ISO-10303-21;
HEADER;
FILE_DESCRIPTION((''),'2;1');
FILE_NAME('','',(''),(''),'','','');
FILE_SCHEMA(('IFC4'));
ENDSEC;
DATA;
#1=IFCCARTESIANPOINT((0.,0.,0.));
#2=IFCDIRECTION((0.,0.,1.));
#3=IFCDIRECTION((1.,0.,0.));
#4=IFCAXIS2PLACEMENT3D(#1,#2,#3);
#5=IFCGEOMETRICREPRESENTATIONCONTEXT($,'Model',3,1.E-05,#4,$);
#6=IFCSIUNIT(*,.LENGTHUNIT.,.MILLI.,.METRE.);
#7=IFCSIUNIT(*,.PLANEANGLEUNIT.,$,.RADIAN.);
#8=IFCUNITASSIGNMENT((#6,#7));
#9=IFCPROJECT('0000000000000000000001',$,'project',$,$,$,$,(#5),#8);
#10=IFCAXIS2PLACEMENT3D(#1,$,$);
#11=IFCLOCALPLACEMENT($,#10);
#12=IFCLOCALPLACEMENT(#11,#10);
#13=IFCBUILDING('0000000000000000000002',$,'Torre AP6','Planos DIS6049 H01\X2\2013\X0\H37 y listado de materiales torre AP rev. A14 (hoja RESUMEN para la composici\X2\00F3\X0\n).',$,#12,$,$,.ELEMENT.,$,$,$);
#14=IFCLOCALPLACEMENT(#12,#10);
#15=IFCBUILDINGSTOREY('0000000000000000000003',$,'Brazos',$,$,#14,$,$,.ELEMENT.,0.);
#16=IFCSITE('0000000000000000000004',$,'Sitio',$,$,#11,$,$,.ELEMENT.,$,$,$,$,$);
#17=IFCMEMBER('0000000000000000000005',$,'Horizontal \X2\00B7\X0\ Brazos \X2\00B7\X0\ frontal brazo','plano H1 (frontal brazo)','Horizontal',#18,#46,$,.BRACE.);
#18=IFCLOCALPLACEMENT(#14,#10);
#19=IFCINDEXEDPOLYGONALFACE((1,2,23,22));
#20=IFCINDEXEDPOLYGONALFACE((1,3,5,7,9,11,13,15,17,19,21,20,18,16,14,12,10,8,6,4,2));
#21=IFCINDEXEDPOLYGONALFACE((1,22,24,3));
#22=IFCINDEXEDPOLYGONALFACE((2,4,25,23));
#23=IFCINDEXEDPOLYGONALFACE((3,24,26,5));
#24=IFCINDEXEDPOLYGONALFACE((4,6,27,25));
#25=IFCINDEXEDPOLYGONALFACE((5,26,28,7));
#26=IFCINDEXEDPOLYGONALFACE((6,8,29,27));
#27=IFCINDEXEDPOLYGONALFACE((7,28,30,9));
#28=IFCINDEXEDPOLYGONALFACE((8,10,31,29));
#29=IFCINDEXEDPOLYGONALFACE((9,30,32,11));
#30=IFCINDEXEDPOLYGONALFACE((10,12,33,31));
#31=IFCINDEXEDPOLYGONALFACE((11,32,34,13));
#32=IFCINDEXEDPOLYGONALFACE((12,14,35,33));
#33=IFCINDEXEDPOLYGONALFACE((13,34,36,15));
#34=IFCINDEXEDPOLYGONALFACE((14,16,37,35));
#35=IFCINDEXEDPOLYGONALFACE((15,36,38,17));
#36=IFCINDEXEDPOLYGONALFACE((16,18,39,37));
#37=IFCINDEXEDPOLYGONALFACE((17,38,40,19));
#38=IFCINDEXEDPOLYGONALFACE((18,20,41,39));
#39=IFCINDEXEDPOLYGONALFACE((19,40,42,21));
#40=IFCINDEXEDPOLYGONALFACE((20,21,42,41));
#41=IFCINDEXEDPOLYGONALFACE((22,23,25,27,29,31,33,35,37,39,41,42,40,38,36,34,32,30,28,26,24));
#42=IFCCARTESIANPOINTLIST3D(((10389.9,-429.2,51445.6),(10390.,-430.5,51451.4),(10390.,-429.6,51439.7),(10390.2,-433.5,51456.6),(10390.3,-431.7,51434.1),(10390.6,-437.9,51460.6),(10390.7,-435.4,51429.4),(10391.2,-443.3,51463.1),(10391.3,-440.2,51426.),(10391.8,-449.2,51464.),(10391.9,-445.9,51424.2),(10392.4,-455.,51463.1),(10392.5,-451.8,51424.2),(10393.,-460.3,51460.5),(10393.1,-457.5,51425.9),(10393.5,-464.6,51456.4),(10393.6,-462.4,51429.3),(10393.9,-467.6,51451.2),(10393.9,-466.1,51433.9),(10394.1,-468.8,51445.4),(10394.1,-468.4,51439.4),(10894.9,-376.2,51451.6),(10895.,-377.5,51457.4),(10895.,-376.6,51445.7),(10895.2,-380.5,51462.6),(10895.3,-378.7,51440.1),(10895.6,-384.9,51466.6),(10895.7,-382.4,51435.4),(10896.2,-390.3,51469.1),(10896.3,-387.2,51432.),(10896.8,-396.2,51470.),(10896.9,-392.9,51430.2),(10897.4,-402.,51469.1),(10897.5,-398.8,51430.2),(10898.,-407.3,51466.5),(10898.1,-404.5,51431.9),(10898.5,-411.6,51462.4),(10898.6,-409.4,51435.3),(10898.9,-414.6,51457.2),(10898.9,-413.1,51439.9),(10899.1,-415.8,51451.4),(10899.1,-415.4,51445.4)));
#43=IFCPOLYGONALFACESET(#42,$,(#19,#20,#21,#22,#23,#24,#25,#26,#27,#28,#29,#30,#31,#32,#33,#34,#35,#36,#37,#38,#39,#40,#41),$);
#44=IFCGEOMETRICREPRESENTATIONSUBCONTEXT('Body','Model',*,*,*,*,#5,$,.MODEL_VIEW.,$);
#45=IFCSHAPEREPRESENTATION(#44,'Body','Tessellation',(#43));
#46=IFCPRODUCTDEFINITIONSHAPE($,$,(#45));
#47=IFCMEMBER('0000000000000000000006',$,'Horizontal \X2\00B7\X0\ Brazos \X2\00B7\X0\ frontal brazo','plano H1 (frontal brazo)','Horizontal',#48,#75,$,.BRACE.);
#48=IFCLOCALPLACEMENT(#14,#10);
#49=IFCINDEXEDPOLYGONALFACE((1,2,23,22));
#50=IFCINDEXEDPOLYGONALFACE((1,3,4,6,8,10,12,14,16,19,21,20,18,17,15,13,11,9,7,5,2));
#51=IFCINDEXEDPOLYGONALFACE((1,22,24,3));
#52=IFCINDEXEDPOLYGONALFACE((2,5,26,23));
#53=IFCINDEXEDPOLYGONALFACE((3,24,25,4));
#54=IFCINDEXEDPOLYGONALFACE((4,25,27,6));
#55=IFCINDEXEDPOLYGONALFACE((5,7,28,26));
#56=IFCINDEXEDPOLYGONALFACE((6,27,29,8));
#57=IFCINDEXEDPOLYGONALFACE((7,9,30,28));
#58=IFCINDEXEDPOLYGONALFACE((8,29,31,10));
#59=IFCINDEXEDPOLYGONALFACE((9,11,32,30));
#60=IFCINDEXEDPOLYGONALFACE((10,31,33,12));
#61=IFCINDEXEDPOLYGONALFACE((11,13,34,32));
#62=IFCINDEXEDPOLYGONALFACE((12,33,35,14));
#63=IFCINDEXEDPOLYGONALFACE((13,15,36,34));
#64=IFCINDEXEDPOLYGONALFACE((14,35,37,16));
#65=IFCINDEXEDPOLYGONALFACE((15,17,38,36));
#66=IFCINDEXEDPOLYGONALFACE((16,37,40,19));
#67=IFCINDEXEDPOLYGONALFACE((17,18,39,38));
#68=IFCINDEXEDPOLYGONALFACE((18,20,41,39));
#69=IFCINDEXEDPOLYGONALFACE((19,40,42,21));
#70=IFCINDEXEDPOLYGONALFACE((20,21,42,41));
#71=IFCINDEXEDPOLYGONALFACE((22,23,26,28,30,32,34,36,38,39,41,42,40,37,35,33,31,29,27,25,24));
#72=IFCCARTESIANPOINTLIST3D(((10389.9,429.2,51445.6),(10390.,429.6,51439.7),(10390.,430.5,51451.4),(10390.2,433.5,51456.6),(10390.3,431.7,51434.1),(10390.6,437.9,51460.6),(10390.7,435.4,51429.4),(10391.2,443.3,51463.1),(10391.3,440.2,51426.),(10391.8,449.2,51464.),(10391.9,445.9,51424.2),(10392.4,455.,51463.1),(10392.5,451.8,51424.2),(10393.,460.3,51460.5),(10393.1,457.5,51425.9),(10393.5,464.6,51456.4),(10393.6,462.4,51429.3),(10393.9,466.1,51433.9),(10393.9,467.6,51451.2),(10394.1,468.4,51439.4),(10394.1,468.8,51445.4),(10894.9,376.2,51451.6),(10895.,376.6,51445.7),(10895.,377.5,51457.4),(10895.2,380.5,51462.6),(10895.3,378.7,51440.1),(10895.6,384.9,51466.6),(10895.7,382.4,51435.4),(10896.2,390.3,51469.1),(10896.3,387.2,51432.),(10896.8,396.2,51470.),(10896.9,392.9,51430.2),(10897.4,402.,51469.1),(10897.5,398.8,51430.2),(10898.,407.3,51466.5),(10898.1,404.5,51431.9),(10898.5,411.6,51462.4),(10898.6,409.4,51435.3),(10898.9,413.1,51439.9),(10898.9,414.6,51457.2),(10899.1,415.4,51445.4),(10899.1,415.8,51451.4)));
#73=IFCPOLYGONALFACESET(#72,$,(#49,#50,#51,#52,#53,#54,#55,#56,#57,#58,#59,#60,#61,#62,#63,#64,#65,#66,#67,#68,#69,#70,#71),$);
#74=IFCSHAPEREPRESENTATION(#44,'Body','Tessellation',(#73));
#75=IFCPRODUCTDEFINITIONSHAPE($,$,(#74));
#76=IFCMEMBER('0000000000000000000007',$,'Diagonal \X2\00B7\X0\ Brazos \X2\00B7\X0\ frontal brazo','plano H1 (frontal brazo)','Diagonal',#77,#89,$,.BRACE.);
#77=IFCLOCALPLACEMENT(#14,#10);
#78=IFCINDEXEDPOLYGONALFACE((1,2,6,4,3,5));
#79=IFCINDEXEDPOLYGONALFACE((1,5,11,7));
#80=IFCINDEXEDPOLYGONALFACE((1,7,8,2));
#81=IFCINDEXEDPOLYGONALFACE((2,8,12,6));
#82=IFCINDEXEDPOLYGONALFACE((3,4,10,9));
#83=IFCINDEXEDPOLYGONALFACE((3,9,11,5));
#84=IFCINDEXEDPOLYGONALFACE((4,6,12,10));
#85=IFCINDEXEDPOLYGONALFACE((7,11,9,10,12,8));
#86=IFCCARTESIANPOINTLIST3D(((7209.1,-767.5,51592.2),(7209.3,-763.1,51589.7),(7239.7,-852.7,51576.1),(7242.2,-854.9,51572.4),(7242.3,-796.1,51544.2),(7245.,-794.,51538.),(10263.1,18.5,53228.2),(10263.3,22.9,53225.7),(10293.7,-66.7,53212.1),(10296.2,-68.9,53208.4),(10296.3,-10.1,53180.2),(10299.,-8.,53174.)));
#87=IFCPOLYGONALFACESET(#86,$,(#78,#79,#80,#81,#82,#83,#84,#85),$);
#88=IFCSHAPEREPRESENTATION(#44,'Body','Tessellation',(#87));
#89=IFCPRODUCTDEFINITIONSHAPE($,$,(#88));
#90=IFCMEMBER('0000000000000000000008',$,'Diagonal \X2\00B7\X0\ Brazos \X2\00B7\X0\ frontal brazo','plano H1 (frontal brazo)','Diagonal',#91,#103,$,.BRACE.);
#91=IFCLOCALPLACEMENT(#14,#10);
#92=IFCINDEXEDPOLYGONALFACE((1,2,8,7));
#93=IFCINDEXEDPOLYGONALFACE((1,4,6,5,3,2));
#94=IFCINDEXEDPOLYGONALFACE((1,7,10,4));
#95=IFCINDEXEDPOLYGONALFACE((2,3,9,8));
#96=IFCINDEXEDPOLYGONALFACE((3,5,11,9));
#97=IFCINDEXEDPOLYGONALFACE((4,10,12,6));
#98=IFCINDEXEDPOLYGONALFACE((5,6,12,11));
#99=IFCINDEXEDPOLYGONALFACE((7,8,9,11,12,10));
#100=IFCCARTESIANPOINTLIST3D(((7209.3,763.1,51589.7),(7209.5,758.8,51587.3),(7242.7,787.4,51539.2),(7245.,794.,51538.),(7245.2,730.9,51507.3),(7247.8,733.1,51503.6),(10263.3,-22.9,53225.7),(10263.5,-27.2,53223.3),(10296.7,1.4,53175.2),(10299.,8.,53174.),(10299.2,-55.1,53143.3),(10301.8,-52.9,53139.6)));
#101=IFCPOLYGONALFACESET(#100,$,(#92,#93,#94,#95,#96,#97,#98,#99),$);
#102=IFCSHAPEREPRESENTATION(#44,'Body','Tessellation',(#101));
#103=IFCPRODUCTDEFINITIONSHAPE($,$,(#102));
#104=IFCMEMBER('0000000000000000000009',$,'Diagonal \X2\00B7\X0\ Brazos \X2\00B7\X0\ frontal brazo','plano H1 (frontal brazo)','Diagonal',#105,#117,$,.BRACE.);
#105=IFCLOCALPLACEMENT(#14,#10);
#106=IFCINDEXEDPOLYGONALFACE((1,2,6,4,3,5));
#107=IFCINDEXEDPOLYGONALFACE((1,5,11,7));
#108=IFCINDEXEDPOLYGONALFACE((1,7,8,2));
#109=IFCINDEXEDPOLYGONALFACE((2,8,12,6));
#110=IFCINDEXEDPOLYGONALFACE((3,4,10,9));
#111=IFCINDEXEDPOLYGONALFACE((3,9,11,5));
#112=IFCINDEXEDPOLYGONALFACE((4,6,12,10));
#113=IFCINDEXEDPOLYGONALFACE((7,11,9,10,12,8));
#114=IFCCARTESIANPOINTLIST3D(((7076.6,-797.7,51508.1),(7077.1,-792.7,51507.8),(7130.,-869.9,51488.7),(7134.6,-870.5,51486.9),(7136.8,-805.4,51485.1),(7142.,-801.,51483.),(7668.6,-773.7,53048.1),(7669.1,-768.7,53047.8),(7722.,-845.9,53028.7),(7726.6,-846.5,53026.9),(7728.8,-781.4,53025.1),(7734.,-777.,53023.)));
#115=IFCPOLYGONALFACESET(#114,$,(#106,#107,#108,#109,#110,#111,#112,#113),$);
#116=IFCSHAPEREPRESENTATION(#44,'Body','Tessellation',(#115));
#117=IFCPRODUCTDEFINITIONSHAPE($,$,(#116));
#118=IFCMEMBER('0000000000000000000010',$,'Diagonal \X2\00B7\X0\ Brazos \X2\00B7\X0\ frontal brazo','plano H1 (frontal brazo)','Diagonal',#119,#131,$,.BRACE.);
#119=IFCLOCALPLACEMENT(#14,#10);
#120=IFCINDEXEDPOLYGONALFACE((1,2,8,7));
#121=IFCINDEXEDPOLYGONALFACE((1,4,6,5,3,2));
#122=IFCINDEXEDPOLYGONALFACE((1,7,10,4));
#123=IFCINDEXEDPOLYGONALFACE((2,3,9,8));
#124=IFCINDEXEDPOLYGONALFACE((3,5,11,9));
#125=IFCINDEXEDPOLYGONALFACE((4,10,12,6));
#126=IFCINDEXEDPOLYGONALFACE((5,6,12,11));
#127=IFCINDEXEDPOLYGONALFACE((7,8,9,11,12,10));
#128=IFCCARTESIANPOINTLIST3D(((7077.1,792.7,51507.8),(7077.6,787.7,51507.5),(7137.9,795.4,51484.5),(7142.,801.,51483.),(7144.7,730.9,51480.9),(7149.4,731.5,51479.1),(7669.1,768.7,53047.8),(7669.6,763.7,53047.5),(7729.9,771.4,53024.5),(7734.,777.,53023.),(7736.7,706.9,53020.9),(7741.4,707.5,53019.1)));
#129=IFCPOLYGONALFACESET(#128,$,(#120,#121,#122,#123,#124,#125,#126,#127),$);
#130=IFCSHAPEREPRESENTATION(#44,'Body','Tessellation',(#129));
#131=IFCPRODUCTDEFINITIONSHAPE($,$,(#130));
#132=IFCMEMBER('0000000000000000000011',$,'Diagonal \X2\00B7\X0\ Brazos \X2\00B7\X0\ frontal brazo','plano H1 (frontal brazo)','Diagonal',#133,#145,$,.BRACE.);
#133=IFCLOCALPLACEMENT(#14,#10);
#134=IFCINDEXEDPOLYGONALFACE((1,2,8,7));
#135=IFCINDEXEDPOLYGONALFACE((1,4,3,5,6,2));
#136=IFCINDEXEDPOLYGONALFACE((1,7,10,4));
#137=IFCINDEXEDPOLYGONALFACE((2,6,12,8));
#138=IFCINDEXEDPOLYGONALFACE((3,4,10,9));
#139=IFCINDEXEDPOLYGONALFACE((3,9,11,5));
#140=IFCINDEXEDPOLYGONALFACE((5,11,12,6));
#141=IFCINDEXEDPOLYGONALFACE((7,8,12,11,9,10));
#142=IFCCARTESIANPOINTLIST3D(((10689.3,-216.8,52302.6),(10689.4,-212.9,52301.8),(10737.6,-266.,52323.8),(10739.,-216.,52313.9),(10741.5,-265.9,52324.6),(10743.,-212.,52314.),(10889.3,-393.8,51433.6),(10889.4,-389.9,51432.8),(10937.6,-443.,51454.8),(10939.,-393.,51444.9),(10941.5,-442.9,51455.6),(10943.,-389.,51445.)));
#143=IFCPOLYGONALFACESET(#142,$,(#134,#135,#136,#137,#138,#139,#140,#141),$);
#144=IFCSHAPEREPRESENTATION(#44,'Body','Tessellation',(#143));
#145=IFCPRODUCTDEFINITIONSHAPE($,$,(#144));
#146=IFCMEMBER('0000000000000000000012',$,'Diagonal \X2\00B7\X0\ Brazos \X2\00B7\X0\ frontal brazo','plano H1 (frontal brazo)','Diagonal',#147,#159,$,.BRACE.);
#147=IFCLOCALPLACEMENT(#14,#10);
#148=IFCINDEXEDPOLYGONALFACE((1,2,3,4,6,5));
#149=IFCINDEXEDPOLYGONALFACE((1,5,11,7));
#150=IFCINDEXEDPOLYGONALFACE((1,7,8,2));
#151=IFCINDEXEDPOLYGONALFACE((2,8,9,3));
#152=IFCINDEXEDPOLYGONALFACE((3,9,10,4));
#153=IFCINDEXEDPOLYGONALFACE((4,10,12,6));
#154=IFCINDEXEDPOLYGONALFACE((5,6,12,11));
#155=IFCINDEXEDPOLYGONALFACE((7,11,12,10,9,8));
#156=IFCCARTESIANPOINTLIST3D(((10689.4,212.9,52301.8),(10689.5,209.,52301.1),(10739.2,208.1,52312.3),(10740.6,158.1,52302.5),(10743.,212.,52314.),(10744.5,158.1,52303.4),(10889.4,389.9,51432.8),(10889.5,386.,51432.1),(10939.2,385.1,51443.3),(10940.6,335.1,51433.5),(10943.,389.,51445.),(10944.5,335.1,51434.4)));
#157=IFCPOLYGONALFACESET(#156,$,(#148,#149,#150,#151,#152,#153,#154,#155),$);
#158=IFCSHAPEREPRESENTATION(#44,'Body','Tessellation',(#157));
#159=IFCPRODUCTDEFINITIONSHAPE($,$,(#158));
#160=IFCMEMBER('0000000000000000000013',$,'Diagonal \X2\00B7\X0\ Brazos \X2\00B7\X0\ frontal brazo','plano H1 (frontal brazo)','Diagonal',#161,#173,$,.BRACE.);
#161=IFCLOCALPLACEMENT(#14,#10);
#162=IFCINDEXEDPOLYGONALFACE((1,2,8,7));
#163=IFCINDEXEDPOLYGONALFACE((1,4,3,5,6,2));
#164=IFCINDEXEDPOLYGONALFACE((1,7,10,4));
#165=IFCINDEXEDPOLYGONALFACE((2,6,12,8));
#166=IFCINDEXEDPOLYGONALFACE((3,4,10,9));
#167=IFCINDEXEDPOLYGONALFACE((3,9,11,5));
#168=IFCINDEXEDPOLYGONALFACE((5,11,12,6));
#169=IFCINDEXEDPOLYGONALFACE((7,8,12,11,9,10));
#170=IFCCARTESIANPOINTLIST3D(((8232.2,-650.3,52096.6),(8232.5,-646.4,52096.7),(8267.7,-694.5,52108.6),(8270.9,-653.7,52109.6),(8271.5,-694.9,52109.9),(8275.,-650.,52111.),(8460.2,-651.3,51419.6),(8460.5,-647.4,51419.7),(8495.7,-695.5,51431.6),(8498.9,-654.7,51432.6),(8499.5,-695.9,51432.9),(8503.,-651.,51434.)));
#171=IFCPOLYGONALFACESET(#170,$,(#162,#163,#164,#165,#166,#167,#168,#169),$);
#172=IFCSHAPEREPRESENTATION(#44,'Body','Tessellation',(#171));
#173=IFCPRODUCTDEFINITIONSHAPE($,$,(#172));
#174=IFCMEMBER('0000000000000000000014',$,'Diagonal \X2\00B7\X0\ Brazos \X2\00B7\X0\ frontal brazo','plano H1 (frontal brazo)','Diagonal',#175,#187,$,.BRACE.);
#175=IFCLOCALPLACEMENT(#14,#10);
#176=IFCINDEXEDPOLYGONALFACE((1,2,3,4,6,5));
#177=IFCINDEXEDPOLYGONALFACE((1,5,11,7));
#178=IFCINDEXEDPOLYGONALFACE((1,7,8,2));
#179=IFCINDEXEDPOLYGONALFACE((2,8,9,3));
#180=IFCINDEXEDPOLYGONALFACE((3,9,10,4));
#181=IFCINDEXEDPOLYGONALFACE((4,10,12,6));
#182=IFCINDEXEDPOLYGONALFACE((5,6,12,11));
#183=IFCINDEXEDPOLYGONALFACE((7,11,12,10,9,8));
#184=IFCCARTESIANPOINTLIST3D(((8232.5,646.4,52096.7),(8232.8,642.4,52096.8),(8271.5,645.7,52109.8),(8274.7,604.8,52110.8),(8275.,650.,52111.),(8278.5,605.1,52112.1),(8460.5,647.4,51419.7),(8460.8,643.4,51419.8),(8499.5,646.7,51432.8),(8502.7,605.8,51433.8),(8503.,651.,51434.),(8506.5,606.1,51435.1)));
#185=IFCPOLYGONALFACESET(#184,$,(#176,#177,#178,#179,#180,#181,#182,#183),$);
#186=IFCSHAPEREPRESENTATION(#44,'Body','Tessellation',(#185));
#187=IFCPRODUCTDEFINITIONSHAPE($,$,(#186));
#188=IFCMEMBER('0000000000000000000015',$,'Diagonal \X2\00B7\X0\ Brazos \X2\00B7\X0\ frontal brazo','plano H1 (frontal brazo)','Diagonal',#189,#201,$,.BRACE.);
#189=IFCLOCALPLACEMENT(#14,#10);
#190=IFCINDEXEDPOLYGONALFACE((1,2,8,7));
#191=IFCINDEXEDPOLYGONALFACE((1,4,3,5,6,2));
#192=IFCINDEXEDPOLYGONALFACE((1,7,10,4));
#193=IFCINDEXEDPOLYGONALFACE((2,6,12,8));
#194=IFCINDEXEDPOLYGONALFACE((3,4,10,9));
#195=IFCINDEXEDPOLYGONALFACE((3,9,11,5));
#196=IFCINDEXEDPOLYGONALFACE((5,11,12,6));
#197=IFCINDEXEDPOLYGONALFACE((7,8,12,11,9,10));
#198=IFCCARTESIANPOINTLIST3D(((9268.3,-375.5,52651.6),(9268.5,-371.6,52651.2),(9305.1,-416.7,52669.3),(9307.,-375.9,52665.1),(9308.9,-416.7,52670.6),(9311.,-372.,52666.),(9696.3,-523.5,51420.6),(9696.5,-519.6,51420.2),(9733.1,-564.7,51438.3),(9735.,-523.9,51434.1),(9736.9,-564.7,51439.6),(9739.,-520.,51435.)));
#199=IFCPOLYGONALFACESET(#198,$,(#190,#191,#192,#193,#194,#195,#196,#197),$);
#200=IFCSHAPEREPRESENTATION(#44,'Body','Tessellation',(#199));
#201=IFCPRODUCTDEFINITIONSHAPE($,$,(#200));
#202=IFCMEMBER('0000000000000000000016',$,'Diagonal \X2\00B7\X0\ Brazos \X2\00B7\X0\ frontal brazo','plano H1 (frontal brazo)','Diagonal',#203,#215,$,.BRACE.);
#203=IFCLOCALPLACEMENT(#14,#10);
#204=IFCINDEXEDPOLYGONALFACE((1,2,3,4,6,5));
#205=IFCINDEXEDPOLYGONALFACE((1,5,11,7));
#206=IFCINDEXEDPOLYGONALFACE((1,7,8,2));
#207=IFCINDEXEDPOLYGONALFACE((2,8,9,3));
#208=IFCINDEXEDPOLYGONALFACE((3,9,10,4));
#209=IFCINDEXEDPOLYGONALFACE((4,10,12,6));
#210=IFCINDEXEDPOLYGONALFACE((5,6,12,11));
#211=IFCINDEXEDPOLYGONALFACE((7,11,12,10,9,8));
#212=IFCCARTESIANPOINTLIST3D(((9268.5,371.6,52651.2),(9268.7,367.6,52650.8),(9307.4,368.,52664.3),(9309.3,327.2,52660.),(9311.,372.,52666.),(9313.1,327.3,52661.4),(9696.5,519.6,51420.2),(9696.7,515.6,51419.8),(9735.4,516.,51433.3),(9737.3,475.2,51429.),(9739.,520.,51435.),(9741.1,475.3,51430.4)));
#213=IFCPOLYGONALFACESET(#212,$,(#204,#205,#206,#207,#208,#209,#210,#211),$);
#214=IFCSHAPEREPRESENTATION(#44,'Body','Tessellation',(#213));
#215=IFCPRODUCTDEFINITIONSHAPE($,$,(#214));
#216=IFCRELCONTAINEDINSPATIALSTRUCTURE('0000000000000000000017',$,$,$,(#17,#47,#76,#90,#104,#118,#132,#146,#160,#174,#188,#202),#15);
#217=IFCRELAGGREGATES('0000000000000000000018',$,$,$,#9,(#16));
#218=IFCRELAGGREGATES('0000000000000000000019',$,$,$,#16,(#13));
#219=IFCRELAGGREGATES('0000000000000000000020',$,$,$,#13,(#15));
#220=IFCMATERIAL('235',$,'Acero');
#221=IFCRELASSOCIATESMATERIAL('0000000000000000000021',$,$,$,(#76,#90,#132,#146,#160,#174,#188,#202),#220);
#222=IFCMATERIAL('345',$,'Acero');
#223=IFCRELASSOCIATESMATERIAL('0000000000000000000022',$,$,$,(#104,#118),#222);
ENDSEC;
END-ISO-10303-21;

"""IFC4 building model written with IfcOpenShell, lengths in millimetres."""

from ifc_helpers import new_model, si_unit, frame, frame_2d, origin, origin_with_axes, place, context, subcontext, project, spatial, circle, l_section, extrude, material, element, save


model = new_model("IFC4")

# Units and contexts
model_context = context("Model", 3, precision=1e-05, world=origin_with_axes())
body_context = subcontext(model_context, "Body", "Model", "MODEL_VIEW")
ifc_project = project(units=[si_unit("LENGTHUNIT", "METRE", prefix="MILLI"), si_unit("PLANEANGLEUNIT", "RADIAN")], contexts=[model_context])

# Site, building, storey
site_placement = place(None, origin())
site = spatial("IfcSite", under=ifc_project, at=site_placement, Name="Sitio", CompositionType="ELEMENT")
building_placement = place(site_placement, origin())
building = spatial("IfcBuilding", under=site, at=building_placement, Name="Torre AP6", Description="Planos DIS6049 H01–H37 y listado de materiales torre AP rev. A14 (hoja RESUMEN para la composición).", CompositionType="ELEMENT")
storey_placement = place(building_placement, origin())
storey = spatial("IfcBuildingStorey", under=building, at=storey_placement, Name="Brazos", CompositionType="ELEMENT", Elevation=0.0)

# Members
for number, where, z_axis, x_axis, name in (
    (1, (10392.0, -449.0, 51444.0), (0.994468, 0.10437, 0.011815), (-0.104986, 0.991163, 0.081074), "Horizontal · Brazos · frontal brazo"),
    (2, (10392.0, 449.0, 51444.0), (0.994468, -0.10437, 0.011815), (-0.104986, -0.991163, 0.081074), "Horizontal · Brazos · frontal brazo"),
):
    element("IfcMember", number, at=place(storey_placement, frame(where, z_axis=z_axis, x_axis=x_axis)), inside=storey, Name=name, Description="plano H1 (frontal brazo)", ObjectType="Horizontal", PredefinedType="BRACE", context=body_context, shape_type="SweptSolid", body=[
        extrude(circle(Radius=20.0), None, (0.0, 0.0, 1.0), 507.8),
    ])
ifc_material_1 = material(Name="235", Category="Acero")
for number, where, z_axis, x_axis, name in (
    (3, (7245.0, -794.0, 51538.0), (0.859644, 0.221244, 0.460503), (-0.509345, 0.441284, 0.738808), "Diagonal · Brazos · frontal brazo"),
    (4, (7245.0, 794.0, 51538.0), (0.859644, -0.221244, 0.460503), (-0.509345, -0.441284, 0.738808), "Diagonal · Brazos · frontal brazo"),
):
    element("IfcMember", number, at=place(storey_placement, frame(where, z_axis=z_axis, x_axis=x_axis)), inside=storey, material=ifc_material_1, Name=name, Description="plano H1 (frontal brazo)", ObjectType="Diagonal", PredefinedType="BRACE", context=body_context, shape_type="SweptSolid", body=[
        extrude(l_section(Depth=70.0, Width=70.0, Thickness=5.0, at=frame_2d((35.0, 35.0))), None, (0.0, 0.0, 1.0), 3552.6),
    ])
ifc_material_2 = material(Name="345", Category="Acero")
for number, where, z_axis, x_axis, name in (
    (5, (7142.0, -801.0, 51483.0), (0.358779, 0.014545, 0.933309), (-0.927462, 0.118373, 0.354686), "Diagonal · Brazos · frontal brazo"),
    (6, (7142.0, 801.0, 51483.0), (0.358779, -0.014545, 0.933309), (-0.927462, -0.118373, 0.354686), "Diagonal · Brazos · frontal brazo"),
):
    element("IfcMember", number, at=place(storey_placement, frame(where, z_axis=z_axis, x_axis=x_axis)), inside=storey, material=ifc_material_2, Name=name, Description="plano H1 (frontal brazo)", ObjectType="Diagonal", PredefinedType="BRACE", context=body_context, shape_type="SweptSolid", body=[
        extrude(l_section(Depth=70.0, Width=70.0, Thickness=5.0, at=frame_2d((35.0, 35.0))), None, (0.0, 0.0, 1.0), 1650.0),
    ])
for number, where, z_axis, x_axis, name in (
    (7, (10943.0, -389.0, 51445.0), (-0.219994, 0.194695, 0.955875), (-0.975122, -0.016589, -0.221045), "Diagonal · Brazos · frontal brazo"),
    (8, (10943.0, 389.0, 51445.0), (-0.219994, -0.194695, 0.955875), (-0.975122, 0.016589, -0.221045), "Diagonal · Brazos · frontal brazo"),
):
    element("IfcMember", number, at=place(storey_placement, frame(where, z_axis=z_axis, x_axis=x_axis)), inside=storey, material=ifc_material_1, Name=name, Description="plano H1 (frontal brazo)", ObjectType="Diagonal", PredefinedType="BRACE", context=body_context, shape_type="SweptSolid", body=[
        extrude(l_section(Depth=55.0, Width=55.0, Thickness=4.0, at=frame_2d((27.5, 27.5))), None, (0.0, 0.0, 1.0), 909.1),
    ])
for number, where, z_axis, x_axis, name in (
    (9, (8503.0, -651.0, 51434.0), (-0.319166, 0.0014, 0.947698), (-0.944542, 0.081082, -0.318223), "Diagonal · Brazos · frontal brazo"),
    (10, (8503.0, 651.0, 51434.0), (-0.319166, -0.0014, 0.947698), (-0.944542, -0.081082, -0.318223), "Diagonal · Brazos · frontal brazo"),
):
    element("IfcMember", number, at=place(storey_placement, frame(where, z_axis=z_axis, x_axis=x_axis)), inside=storey, material=ifc_material_1, Name=name, Description="plano H1 (frontal brazo)", ObjectType="Diagonal", PredefinedType="BRACE", context=body_context, shape_type="SweptSolid", body=[
        extrude(l_section(Depth=45.0, Width=45.0, Thickness=4.0, at=frame_2d((22.5, 22.5))), None, (0.0, 0.0, 1.0), 714.4),
    ])
for number, where, z_axis, x_axis, name in (
    (11, (9739.0, -520.0, 51435.0), (-0.326304, 0.112834, 0.938506), (-0.944119, 0.009962, -0.329454), "Diagonal · Brazos · frontal brazo"),
    (12, (9739.0, 520.0, 51435.0), (-0.326304, -0.112834, 0.938506), (-0.944119, -0.009962, -0.329454), "Diagonal · Brazos · frontal brazo"),
):
    element("IfcMember", number, at=place(storey_placement, frame(where, z_axis=z_axis, x_axis=x_axis)), inside=storey, material=ifc_material_1, Name=name, Description="plano H1 (frontal brazo)", ObjectType="Diagonal", PredefinedType="BRACE", context=body_context, shape_type="SweptSolid", body=[
        extrude(l_section(Depth=45.0, Width=45.0, Thickness=4.0, at=frame_2d((22.5, 22.5))), None, (0.0, 0.0, 1.0), 1311.7),
    ])

save(model, "model.ifc")
